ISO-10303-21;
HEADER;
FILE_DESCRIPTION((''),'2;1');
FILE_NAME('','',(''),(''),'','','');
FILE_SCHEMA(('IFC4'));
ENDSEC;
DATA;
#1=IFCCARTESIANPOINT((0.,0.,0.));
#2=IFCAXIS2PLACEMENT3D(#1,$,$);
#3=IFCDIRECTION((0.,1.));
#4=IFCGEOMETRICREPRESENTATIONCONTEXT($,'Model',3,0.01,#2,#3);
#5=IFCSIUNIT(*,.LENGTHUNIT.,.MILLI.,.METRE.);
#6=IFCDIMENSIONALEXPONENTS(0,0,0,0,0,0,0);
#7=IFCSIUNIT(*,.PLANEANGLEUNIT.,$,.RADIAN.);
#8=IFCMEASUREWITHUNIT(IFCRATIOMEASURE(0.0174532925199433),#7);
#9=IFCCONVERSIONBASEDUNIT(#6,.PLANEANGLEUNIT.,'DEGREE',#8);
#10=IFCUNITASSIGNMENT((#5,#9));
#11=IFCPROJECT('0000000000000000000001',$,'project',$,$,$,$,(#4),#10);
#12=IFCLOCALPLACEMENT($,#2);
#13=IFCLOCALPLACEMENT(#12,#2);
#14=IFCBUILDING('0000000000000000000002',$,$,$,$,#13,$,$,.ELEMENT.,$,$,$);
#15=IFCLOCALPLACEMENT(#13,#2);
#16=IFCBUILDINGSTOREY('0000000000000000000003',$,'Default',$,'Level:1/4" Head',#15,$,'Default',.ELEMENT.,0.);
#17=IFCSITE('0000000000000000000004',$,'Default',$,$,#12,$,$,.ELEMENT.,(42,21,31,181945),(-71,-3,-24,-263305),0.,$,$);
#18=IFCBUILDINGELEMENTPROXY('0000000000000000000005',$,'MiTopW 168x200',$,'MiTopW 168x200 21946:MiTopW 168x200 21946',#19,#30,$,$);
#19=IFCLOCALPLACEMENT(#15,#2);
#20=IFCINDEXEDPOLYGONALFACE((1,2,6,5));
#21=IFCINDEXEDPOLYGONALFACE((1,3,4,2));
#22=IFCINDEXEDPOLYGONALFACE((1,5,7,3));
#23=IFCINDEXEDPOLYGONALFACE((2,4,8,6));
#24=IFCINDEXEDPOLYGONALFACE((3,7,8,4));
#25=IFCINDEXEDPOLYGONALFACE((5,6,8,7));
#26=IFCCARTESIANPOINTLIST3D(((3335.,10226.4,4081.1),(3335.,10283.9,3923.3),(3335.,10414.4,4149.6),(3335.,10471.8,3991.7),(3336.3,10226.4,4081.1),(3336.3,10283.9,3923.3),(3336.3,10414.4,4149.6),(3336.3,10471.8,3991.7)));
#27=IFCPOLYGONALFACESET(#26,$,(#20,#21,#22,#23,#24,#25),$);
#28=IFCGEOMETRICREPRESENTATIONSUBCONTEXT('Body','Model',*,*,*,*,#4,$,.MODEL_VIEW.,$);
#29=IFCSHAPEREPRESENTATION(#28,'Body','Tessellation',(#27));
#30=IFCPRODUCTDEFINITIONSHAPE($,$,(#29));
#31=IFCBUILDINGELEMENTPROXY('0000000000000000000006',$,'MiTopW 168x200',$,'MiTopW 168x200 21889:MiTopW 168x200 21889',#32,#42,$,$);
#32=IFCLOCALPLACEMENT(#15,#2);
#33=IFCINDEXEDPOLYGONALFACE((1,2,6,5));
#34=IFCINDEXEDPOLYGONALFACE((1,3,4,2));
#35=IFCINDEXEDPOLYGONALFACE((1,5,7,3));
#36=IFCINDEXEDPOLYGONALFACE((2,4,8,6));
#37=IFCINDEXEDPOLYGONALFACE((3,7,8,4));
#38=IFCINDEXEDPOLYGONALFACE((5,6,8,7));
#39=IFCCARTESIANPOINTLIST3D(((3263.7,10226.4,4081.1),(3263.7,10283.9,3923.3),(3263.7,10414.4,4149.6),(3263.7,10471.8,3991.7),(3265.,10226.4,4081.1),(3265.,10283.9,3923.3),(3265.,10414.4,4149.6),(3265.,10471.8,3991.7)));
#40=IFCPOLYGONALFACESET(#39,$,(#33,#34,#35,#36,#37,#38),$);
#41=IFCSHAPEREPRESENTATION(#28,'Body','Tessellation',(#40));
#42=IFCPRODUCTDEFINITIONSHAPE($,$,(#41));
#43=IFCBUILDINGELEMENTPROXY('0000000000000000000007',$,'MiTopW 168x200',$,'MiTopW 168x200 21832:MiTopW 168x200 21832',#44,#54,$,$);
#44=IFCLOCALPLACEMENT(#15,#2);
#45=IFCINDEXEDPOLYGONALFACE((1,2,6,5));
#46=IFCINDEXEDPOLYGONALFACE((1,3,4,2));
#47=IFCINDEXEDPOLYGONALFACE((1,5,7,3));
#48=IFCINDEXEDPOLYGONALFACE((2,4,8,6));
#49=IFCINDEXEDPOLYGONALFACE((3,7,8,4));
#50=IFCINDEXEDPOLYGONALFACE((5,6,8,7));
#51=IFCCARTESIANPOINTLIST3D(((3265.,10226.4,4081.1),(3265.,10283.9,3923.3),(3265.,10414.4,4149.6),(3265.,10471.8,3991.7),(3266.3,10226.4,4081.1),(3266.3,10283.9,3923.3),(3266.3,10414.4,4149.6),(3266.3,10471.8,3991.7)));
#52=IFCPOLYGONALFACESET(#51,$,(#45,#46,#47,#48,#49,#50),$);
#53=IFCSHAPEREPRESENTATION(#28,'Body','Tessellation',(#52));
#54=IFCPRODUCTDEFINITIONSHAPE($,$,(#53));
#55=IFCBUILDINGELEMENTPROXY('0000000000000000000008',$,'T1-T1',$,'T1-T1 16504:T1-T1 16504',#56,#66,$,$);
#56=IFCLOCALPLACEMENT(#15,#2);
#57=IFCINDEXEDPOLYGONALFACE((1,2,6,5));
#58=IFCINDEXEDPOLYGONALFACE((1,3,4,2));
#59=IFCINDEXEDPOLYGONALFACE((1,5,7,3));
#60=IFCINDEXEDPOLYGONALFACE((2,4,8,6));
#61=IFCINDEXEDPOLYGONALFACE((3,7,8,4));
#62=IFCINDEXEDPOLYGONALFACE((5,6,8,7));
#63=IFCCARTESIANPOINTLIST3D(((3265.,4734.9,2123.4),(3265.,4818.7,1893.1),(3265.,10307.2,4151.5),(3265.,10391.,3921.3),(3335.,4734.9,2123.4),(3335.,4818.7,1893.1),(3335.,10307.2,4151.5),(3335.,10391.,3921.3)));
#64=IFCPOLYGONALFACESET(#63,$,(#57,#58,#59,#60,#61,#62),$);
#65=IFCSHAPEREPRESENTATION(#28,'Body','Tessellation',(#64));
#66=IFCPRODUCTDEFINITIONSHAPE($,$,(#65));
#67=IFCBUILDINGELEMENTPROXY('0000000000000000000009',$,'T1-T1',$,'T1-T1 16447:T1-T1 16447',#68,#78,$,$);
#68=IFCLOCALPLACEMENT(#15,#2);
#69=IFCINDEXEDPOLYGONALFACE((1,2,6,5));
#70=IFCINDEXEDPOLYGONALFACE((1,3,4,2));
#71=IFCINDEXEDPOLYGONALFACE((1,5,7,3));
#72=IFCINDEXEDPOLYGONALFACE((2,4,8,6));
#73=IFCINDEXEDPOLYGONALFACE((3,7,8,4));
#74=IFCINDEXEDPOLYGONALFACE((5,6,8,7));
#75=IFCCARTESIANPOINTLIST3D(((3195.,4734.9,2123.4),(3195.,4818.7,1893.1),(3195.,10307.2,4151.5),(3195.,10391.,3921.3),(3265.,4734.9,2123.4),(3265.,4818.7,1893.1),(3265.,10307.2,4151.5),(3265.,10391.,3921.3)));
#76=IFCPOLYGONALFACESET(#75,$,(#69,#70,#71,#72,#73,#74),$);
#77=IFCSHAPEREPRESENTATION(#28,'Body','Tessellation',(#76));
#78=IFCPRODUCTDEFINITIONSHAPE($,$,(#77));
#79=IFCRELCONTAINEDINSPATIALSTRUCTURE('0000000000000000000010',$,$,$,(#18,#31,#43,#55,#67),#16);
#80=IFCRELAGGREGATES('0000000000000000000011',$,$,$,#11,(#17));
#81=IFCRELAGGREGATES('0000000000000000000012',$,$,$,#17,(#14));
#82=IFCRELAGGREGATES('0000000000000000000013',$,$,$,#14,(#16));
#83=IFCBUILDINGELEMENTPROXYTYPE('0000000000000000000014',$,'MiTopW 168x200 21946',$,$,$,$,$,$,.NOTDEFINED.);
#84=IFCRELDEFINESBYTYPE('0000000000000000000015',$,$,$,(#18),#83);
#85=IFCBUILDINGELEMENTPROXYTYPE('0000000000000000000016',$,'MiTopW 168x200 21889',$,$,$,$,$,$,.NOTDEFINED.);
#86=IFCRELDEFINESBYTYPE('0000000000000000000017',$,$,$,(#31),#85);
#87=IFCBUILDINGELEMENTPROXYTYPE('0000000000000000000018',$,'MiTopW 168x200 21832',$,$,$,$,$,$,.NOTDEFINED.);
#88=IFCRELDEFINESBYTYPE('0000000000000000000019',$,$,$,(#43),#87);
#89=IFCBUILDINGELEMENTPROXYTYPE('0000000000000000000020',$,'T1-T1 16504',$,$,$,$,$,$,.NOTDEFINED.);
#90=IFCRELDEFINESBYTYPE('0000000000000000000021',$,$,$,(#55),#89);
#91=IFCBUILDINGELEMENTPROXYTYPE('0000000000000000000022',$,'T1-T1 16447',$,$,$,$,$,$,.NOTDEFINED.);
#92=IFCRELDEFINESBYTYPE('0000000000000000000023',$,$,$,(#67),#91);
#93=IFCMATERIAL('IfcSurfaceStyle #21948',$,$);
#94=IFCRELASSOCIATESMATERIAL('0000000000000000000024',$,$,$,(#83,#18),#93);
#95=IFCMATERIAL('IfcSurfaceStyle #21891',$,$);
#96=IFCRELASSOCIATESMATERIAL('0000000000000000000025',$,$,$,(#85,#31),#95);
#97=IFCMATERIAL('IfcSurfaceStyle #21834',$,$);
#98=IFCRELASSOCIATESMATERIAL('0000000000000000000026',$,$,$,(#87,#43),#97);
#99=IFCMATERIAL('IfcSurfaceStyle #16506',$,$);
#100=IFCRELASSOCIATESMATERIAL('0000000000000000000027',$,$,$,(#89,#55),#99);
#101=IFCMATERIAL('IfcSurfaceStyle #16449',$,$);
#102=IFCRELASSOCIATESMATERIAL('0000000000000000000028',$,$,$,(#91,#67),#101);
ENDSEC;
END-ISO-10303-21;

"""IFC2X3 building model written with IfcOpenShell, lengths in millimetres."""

from ifc_helpers import new_model, entity, si_unit, converted_unit, direction, frame, origin, place, context, subcontext, project, spatial, polyline, outline, extrude, source, transform, mapped, material, type_object, type_shapes, element, save


model = new_model("IFC2X3")

# Units and contexts
model_context = context("Model", 3, precision=0.01, world=origin(), true_north=direction((0.0, 1.0)))
body_context = subcontext(model_context, "Body", "Model", "MODEL_VIEW")
ifc_project = project(units=[si_unit("LENGTHUNIT", "METRE", prefix="MILLI"), converted_unit("PLANEANGLEUNIT", "DEGREE", entity("IfcRatioMeasure", 0.0174532925199433), si_unit("PLANEANGLEUNIT", "RADIAN"), dimensions=[0, 0, 0, 0, 0, 0, 0])], contexts=[model_context])

# Site, building, storey
site_placement = place(None, origin())
site = spatial("IfcSite", under=ifc_project, at=site_placement, Name="Default", CompositionType="ELEMENT", RefLatitude=(42, 21, 31, 181945), RefLongitude=(-71, -3, -24, -263305), RefElevation=0.0)
building_placement = place(site_placement, origin())
building = spatial("IfcBuilding", under=site, at=building_placement, CompositionType="ELEMENT")
storey_placement = place(building_placement, origin())
storey = spatial("IfcBuildingStorey", under=building, at=storey_placement, Name="Default", ObjectType="Level:1/4\" Head", LongName="Default", CompositionType="ELEMENT", Elevation=0.0)

# Building element proxies
ifc_material_1 = material(Name="IfcSurfaceStyle #21948")
building_element_proxy_type_1 = type_object("IfcBuildingElementProxyType", Name="MiTopW 168x200 21946", PredefinedType="NOTDEFINED", material=ifc_material_1)
shared_shape_1 = source(origin(), body_context, "Body", "SweptSolid", [
    extrude(outline(polyline([(-100.0, -84.0), (100.0, -84.0), (100.0, 84.0), (-100.0, 84.0), (-100.0, -84.0)])), frame((100.0, 84.0, 0.0), z_axis=(0.0, 0.0, 1.0), x_axis=(-1.0, 0.0, 0.0)), (0.0, 0.0, 1.0), 1.3),
])
type_shapes(building_element_proxy_type_1, [shared_shape_1])
proxy_1_placement = place(building_placement, frame((3336.3, 10226.4, 4081.1), z_axis=(-1.0, 0.0, 0.0), x_axis=(0.0, 0.939693, 0.34202)))
element("IfcBuildingElementProxy", 1, at=proxy_1_placement, inside=storey, type_object=building_element_proxy_type_1, material=ifc_material_1, Name="MiTopW 168x200", ObjectType="MiTopW 168x200 21946:MiTopW 168x200 21946", context=body_context, shape_type="MappedRepresentation", body=[
    mapped(shared_shape_1, transform((0.0, 0.0, 0.0), scale=1.0)),
])
ifc_material_2 = material(Name="IfcSurfaceStyle #21891")
building_element_proxy_type_2 = type_object("IfcBuildingElementProxyType", Name="MiTopW 168x200 21889", PredefinedType="NOTDEFINED", material=ifc_material_2)
shared_shape_2 = source(origin(), body_context, "Body", "SweptSolid", [
    extrude(outline(polyline([(-100.0, -84.0), (100.0, -84.0), (100.0, 84.0), (-100.0, 84.0), (-100.0, -84.0)])), frame((100.0, 84.0, 0.0), z_axis=(0.0, 0.0, 1.0), x_axis=(-1.0, 0.0, 0.0)), (0.0, 0.0, 1.0), 1.3),
])
type_shapes(building_element_proxy_type_2, [shared_shape_2])
proxy_2_placement = place(building_placement, frame((3265.0, 10226.4, 4081.1), z_axis=(-1.0, 0.0, 0.0), x_axis=(0.0, 0.939693, 0.34202)))
element("IfcBuildingElementProxy", 2, at=proxy_2_placement, inside=storey, type_object=building_element_proxy_type_2, material=ifc_material_2, Name="MiTopW 168x200", ObjectType="MiTopW 168x200 21889:MiTopW 168x200 21889", context=body_context, shape_type="MappedRepresentation", body=[
    mapped(shared_shape_2, transform((0.0, 0.0, 0.0), scale=1.0)),
])
ifc_material_3 = material(Name="IfcSurfaceStyle #21834")
building_element_proxy_type_3 = type_object("IfcBuildingElementProxyType", Name="MiTopW 168x200 21832", PredefinedType="NOTDEFINED", material=ifc_material_3)
shared_shape_3 = source(origin(), body_context, "Body", "SweptSolid", [
    extrude(outline(polyline([(-100.0, -84.0), (100.0, -84.0), (100.0, 84.0), (-100.0, 84.0), (-100.0, -84.0)])), frame((100.0, 84.0, 0.0), z_axis=(0.0, 0.0, 1.0), x_axis=(-1.0, 0.0, 0.0)), (0.0, 0.0, 1.0), 1.3),
])
type_shapes(building_element_proxy_type_3, [shared_shape_3])
proxy_3_placement = place(building_placement, frame((3266.3, 10226.4, 4081.1), z_axis=(-1.0, 0.0, 0.0), x_axis=(0.0, 0.939693, 0.34202)))
element("IfcBuildingElementProxy", 3, at=proxy_3_placement, inside=storey, type_object=building_element_proxy_type_3, material=ifc_material_3, Name="MiTopW 168x200", ObjectType="MiTopW 168x200 21832:MiTopW 168x200 21832", context=body_context, shape_type="MappedRepresentation", body=[
    mapped(shared_shape_3, transform((0.0, 0.0, 0.0), scale=1.0)),
])
ifc_material_4 = material(Name="IfcSurfaceStyle #16506")
building_element_proxy_type_4 = type_object("IfcBuildingElementProxyType", Name="T1-T1 16504", PredefinedType="NOTDEFINED", material=ifc_material_4)
shared_shape_4 = source(origin(), body_context, "Body", "SweptSolid", [
    extrude(outline(polyline([(-2965.0, -122.5), (2965.0, -122.5), (2965.0, 122.5), (-2965.0, 122.5), (-2965.0, -122.5)])), frame((2965.0, 122.5, 0.0), z_axis=(0.0, 0.0, 1.0), x_axis=(-1.0, 0.0, 0.0)), (0.0, 0.0, 1.0), 70.0),
])
type_shapes(building_element_proxy_type_4, [shared_shape_4])
proxy_4_placement = place(building_placement, frame((3335.0, 10391.0, 3921.3), z_axis=(-1.0, 0.0, 0.0), x_axis=(0.0, -0.939693, -0.34202)))
element("IfcBuildingElementProxy", 4, at=proxy_4_placement, inside=storey, type_object=building_element_proxy_type_4, material=ifc_material_4, Name="T1-T1", ObjectType="T1-T1 16504:T1-T1 16504", context=body_context, shape_type="MappedRepresentation", body=[
    mapped(shared_shape_4, transform((0.0, 0.0, 0.0), scale=1.0)),
])
ifc_material_5 = material(Name="IfcSurfaceStyle #16449")
building_element_proxy_type_5 = type_object("IfcBuildingElementProxyType", Name="T1-T1 16447", PredefinedType="NOTDEFINED", material=ifc_material_5)
shared_shape_5 = source(origin(), body_context, "Body", "SweptSolid", [
    extrude(outline(polyline([(-2965.0, -122.5), (2965.0, -122.5), (2965.0, 122.5), (-2965.0, 122.5), (-2965.0, -122.5)])), frame((2965.0, 122.5, 0.0), z_axis=(0.0, 0.0, 1.0), x_axis=(-1.0, 0.0, 0.0)), (0.0, 0.0, 1.0), 70.0),
])
type_shapes(building_element_proxy_type_5, [shared_shape_5])
proxy_5_placement = place(building_placement, frame((3265.0, 10391.0, 3921.3), z_axis=(-1.0, 0.0, 0.0), x_axis=(0.0, -0.939693, -0.34202)))
element("IfcBuildingElementProxy", 5, at=proxy_5_placement, inside=storey, type_object=building_element_proxy_type_5, material=ifc_material_5, Name="T1-T1", ObjectType="T1-T1 16447:T1-T1 16447", context=body_context, shape_type="MappedRepresentation", body=[
    mapped(shared_shape_5, transform((0.0, 0.0, 0.0), scale=1.0)),
])

save(model, "model.ifc")
